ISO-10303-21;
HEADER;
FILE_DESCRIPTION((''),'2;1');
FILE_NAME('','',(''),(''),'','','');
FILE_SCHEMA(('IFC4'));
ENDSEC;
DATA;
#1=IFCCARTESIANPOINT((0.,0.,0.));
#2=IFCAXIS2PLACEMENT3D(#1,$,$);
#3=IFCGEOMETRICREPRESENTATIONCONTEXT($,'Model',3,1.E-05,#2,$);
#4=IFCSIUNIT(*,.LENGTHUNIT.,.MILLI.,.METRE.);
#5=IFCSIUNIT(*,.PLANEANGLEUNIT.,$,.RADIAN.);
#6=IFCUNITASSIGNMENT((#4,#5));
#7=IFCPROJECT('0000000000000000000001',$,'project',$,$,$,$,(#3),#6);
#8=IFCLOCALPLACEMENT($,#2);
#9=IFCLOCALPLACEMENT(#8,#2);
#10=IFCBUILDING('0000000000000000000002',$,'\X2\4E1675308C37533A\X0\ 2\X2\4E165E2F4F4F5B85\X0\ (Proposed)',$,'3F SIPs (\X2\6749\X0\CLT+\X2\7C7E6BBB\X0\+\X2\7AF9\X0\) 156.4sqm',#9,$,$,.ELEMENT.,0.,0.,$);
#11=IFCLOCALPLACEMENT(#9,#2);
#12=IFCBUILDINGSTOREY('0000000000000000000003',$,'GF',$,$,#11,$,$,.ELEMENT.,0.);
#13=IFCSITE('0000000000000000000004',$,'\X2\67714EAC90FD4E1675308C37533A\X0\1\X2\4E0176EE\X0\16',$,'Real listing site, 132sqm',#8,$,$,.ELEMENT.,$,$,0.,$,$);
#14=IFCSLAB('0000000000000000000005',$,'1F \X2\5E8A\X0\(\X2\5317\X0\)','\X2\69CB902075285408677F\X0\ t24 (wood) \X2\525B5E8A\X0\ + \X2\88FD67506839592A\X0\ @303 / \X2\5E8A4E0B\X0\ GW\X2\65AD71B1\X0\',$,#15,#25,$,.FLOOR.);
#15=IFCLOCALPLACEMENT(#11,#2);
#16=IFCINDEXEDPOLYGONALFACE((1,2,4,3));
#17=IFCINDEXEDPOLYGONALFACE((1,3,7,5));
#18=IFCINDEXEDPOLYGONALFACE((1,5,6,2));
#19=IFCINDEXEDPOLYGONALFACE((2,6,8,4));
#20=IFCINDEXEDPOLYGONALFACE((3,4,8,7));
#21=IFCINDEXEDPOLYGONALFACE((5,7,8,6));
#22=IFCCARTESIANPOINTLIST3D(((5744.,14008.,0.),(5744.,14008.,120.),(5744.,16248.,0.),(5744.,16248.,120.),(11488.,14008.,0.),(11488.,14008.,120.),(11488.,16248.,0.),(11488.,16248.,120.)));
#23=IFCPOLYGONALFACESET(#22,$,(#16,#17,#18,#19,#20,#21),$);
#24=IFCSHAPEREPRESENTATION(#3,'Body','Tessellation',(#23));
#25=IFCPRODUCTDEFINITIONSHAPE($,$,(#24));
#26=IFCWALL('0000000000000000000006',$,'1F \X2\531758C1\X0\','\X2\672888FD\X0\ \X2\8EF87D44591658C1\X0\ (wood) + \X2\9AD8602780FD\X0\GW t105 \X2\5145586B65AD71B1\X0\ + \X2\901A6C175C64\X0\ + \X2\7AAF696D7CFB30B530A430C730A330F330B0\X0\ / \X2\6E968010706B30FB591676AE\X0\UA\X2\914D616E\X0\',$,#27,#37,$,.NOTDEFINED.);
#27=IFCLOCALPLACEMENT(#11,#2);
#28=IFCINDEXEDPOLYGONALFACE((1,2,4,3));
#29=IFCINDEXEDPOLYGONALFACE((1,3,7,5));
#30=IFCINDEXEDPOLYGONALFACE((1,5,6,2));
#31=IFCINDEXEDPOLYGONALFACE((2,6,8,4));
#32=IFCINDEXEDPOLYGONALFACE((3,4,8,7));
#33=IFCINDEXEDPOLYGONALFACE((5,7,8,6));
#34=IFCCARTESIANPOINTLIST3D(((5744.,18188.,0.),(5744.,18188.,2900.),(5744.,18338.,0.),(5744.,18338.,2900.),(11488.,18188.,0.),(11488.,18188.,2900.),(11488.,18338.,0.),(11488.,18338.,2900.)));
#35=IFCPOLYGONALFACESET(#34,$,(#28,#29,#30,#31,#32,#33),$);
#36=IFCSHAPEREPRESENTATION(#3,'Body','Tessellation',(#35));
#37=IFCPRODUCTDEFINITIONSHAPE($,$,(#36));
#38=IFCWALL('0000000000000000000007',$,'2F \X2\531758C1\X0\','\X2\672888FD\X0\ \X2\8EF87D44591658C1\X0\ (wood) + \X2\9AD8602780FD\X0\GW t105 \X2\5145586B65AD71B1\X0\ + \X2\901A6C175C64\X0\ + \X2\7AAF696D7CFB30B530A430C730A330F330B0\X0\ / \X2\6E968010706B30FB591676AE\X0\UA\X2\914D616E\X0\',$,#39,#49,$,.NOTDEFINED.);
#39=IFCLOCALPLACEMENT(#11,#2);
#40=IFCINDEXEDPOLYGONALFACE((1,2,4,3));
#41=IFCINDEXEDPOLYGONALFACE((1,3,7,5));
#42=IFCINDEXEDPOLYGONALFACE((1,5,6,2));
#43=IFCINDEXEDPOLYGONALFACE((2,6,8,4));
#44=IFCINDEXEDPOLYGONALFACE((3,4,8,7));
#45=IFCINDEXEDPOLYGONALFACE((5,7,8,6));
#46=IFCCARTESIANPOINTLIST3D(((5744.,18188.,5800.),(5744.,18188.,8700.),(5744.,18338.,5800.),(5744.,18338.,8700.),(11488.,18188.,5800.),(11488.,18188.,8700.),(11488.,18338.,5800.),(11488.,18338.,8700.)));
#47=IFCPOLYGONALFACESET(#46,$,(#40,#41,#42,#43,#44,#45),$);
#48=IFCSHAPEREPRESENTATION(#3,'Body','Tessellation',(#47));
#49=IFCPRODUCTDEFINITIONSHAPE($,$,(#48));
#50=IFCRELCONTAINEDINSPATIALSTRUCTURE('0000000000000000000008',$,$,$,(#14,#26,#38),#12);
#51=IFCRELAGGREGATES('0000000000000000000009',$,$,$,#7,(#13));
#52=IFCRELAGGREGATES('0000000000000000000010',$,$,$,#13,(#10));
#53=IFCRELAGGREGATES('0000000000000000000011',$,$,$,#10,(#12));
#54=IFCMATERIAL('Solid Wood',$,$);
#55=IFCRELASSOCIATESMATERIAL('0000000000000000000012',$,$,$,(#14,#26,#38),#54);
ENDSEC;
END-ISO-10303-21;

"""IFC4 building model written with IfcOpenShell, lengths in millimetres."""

from ifc_helpers import new_model, si_unit, frame, frame_2d, origin, place, context, project, spatial, rectangle, extrude, material, element, save


model = new_model("IFC4")

# Units and contexts
model_context = context("Model", 3, precision=1e-05, world=origin())
ifc_project = project(units=[si_unit("LENGTHUNIT", "METRE", prefix="MILLI"), si_unit("PLANEANGLEUNIT", "RADIAN")], contexts=[model_context])

# Site, building, storey
site_placement = place(None, origin())
site = spatial("IfcSite", under=ifc_project, at=site_placement, Name="東京都世田谷区1丁目16", ObjectType="Real listing site, 132sqm", CompositionType="ELEMENT", RefElevation=0.0)
building_placement = place(site_placement, origin())
building = spatial("IfcBuilding", under=site, at=building_placement, Name="世田谷区 2世帯住宅 (Proposed)", ObjectType="3F SIPs (杉CLT+籾殻+竹) 156.4sqm", CompositionType="ELEMENT", ElevationOfRefHeight=0.0, ElevationOfTerrain=0.0)
storey_placement = place(building_placement, origin())
storey = spatial("IfcBuildingStorey", under=building, at=storey_placement, Name="GF", CompositionType="ELEMENT", Elevation=0.0)

# Slab
ifc_material_1 = material(Name="Solid Wood")
slab_1_placement = place(storey_placement, frame((2872.0, 7004.0, 0.0)))
element("IfcSlab", 1, at=slab_1_placement, inside=storey, material=ifc_material_1, Name="1F 床(北)", Description="構造用合板 t24 (wood) 剛床 + 製材根太 @303 / 床下 GW断熱", PredefinedType="FLOOR", context=model_context, shape_type="SweptSolid", body=[
    extrude(rectangle(XDim=5744.0, YDim=2240.0, at=frame_2d((2872.0, 1120.0))), frame((2872.0, 7004.0, 0.0)), (0.0, 0.0, 1.0), 120.0),
])

# Wall
wall_1_placement = place(storey_placement, frame((2872.0, 9094.0, 0.0)))
element("IfcWall", 2, at=wall_1_placement, inside=storey, material=ifc_material_1, Name="1F 北壁", Description="木製 軸組外壁 (wood) + 高性能GW t105 充填断熱 + 通気層 + 窯業系サイディング / 準耐火・外皮UA配慮", PredefinedType="NOTDEFINED", context=model_context, shape_type="SweptSolid", body=[
    extrude(rectangle(XDim=5744.0, YDim=150.0, at=frame_2d((2872.0, 75.0))), frame((2872.0, 9094.0, 0.0)), (0.0, 0.0, 1.0), 2900.0),
])

# Wall
wall_2_placement = place(storey_placement, frame((2872.0, 9094.0, 2900.0)))
element("IfcWall", 3, at=wall_2_placement, inside=storey, material=ifc_material_1, Name="2F 北壁", Description="木製 軸組外壁 (wood) + 高性能GW t105 充填断熱 + 通気層 + 窯業系サイディング / 準耐火・外皮UA配慮", PredefinedType="NOTDEFINED", context=model_context, shape_type="SweptSolid", body=[
    extrude(rectangle(XDim=5744.0, YDim=150.0, at=frame_2d((2872.0, 75.0))), frame((2872.0, 9094.0, 2900.0)), (0.0, 0.0, 1.0), 2900.0),
])

save(model, "model.ifc")
